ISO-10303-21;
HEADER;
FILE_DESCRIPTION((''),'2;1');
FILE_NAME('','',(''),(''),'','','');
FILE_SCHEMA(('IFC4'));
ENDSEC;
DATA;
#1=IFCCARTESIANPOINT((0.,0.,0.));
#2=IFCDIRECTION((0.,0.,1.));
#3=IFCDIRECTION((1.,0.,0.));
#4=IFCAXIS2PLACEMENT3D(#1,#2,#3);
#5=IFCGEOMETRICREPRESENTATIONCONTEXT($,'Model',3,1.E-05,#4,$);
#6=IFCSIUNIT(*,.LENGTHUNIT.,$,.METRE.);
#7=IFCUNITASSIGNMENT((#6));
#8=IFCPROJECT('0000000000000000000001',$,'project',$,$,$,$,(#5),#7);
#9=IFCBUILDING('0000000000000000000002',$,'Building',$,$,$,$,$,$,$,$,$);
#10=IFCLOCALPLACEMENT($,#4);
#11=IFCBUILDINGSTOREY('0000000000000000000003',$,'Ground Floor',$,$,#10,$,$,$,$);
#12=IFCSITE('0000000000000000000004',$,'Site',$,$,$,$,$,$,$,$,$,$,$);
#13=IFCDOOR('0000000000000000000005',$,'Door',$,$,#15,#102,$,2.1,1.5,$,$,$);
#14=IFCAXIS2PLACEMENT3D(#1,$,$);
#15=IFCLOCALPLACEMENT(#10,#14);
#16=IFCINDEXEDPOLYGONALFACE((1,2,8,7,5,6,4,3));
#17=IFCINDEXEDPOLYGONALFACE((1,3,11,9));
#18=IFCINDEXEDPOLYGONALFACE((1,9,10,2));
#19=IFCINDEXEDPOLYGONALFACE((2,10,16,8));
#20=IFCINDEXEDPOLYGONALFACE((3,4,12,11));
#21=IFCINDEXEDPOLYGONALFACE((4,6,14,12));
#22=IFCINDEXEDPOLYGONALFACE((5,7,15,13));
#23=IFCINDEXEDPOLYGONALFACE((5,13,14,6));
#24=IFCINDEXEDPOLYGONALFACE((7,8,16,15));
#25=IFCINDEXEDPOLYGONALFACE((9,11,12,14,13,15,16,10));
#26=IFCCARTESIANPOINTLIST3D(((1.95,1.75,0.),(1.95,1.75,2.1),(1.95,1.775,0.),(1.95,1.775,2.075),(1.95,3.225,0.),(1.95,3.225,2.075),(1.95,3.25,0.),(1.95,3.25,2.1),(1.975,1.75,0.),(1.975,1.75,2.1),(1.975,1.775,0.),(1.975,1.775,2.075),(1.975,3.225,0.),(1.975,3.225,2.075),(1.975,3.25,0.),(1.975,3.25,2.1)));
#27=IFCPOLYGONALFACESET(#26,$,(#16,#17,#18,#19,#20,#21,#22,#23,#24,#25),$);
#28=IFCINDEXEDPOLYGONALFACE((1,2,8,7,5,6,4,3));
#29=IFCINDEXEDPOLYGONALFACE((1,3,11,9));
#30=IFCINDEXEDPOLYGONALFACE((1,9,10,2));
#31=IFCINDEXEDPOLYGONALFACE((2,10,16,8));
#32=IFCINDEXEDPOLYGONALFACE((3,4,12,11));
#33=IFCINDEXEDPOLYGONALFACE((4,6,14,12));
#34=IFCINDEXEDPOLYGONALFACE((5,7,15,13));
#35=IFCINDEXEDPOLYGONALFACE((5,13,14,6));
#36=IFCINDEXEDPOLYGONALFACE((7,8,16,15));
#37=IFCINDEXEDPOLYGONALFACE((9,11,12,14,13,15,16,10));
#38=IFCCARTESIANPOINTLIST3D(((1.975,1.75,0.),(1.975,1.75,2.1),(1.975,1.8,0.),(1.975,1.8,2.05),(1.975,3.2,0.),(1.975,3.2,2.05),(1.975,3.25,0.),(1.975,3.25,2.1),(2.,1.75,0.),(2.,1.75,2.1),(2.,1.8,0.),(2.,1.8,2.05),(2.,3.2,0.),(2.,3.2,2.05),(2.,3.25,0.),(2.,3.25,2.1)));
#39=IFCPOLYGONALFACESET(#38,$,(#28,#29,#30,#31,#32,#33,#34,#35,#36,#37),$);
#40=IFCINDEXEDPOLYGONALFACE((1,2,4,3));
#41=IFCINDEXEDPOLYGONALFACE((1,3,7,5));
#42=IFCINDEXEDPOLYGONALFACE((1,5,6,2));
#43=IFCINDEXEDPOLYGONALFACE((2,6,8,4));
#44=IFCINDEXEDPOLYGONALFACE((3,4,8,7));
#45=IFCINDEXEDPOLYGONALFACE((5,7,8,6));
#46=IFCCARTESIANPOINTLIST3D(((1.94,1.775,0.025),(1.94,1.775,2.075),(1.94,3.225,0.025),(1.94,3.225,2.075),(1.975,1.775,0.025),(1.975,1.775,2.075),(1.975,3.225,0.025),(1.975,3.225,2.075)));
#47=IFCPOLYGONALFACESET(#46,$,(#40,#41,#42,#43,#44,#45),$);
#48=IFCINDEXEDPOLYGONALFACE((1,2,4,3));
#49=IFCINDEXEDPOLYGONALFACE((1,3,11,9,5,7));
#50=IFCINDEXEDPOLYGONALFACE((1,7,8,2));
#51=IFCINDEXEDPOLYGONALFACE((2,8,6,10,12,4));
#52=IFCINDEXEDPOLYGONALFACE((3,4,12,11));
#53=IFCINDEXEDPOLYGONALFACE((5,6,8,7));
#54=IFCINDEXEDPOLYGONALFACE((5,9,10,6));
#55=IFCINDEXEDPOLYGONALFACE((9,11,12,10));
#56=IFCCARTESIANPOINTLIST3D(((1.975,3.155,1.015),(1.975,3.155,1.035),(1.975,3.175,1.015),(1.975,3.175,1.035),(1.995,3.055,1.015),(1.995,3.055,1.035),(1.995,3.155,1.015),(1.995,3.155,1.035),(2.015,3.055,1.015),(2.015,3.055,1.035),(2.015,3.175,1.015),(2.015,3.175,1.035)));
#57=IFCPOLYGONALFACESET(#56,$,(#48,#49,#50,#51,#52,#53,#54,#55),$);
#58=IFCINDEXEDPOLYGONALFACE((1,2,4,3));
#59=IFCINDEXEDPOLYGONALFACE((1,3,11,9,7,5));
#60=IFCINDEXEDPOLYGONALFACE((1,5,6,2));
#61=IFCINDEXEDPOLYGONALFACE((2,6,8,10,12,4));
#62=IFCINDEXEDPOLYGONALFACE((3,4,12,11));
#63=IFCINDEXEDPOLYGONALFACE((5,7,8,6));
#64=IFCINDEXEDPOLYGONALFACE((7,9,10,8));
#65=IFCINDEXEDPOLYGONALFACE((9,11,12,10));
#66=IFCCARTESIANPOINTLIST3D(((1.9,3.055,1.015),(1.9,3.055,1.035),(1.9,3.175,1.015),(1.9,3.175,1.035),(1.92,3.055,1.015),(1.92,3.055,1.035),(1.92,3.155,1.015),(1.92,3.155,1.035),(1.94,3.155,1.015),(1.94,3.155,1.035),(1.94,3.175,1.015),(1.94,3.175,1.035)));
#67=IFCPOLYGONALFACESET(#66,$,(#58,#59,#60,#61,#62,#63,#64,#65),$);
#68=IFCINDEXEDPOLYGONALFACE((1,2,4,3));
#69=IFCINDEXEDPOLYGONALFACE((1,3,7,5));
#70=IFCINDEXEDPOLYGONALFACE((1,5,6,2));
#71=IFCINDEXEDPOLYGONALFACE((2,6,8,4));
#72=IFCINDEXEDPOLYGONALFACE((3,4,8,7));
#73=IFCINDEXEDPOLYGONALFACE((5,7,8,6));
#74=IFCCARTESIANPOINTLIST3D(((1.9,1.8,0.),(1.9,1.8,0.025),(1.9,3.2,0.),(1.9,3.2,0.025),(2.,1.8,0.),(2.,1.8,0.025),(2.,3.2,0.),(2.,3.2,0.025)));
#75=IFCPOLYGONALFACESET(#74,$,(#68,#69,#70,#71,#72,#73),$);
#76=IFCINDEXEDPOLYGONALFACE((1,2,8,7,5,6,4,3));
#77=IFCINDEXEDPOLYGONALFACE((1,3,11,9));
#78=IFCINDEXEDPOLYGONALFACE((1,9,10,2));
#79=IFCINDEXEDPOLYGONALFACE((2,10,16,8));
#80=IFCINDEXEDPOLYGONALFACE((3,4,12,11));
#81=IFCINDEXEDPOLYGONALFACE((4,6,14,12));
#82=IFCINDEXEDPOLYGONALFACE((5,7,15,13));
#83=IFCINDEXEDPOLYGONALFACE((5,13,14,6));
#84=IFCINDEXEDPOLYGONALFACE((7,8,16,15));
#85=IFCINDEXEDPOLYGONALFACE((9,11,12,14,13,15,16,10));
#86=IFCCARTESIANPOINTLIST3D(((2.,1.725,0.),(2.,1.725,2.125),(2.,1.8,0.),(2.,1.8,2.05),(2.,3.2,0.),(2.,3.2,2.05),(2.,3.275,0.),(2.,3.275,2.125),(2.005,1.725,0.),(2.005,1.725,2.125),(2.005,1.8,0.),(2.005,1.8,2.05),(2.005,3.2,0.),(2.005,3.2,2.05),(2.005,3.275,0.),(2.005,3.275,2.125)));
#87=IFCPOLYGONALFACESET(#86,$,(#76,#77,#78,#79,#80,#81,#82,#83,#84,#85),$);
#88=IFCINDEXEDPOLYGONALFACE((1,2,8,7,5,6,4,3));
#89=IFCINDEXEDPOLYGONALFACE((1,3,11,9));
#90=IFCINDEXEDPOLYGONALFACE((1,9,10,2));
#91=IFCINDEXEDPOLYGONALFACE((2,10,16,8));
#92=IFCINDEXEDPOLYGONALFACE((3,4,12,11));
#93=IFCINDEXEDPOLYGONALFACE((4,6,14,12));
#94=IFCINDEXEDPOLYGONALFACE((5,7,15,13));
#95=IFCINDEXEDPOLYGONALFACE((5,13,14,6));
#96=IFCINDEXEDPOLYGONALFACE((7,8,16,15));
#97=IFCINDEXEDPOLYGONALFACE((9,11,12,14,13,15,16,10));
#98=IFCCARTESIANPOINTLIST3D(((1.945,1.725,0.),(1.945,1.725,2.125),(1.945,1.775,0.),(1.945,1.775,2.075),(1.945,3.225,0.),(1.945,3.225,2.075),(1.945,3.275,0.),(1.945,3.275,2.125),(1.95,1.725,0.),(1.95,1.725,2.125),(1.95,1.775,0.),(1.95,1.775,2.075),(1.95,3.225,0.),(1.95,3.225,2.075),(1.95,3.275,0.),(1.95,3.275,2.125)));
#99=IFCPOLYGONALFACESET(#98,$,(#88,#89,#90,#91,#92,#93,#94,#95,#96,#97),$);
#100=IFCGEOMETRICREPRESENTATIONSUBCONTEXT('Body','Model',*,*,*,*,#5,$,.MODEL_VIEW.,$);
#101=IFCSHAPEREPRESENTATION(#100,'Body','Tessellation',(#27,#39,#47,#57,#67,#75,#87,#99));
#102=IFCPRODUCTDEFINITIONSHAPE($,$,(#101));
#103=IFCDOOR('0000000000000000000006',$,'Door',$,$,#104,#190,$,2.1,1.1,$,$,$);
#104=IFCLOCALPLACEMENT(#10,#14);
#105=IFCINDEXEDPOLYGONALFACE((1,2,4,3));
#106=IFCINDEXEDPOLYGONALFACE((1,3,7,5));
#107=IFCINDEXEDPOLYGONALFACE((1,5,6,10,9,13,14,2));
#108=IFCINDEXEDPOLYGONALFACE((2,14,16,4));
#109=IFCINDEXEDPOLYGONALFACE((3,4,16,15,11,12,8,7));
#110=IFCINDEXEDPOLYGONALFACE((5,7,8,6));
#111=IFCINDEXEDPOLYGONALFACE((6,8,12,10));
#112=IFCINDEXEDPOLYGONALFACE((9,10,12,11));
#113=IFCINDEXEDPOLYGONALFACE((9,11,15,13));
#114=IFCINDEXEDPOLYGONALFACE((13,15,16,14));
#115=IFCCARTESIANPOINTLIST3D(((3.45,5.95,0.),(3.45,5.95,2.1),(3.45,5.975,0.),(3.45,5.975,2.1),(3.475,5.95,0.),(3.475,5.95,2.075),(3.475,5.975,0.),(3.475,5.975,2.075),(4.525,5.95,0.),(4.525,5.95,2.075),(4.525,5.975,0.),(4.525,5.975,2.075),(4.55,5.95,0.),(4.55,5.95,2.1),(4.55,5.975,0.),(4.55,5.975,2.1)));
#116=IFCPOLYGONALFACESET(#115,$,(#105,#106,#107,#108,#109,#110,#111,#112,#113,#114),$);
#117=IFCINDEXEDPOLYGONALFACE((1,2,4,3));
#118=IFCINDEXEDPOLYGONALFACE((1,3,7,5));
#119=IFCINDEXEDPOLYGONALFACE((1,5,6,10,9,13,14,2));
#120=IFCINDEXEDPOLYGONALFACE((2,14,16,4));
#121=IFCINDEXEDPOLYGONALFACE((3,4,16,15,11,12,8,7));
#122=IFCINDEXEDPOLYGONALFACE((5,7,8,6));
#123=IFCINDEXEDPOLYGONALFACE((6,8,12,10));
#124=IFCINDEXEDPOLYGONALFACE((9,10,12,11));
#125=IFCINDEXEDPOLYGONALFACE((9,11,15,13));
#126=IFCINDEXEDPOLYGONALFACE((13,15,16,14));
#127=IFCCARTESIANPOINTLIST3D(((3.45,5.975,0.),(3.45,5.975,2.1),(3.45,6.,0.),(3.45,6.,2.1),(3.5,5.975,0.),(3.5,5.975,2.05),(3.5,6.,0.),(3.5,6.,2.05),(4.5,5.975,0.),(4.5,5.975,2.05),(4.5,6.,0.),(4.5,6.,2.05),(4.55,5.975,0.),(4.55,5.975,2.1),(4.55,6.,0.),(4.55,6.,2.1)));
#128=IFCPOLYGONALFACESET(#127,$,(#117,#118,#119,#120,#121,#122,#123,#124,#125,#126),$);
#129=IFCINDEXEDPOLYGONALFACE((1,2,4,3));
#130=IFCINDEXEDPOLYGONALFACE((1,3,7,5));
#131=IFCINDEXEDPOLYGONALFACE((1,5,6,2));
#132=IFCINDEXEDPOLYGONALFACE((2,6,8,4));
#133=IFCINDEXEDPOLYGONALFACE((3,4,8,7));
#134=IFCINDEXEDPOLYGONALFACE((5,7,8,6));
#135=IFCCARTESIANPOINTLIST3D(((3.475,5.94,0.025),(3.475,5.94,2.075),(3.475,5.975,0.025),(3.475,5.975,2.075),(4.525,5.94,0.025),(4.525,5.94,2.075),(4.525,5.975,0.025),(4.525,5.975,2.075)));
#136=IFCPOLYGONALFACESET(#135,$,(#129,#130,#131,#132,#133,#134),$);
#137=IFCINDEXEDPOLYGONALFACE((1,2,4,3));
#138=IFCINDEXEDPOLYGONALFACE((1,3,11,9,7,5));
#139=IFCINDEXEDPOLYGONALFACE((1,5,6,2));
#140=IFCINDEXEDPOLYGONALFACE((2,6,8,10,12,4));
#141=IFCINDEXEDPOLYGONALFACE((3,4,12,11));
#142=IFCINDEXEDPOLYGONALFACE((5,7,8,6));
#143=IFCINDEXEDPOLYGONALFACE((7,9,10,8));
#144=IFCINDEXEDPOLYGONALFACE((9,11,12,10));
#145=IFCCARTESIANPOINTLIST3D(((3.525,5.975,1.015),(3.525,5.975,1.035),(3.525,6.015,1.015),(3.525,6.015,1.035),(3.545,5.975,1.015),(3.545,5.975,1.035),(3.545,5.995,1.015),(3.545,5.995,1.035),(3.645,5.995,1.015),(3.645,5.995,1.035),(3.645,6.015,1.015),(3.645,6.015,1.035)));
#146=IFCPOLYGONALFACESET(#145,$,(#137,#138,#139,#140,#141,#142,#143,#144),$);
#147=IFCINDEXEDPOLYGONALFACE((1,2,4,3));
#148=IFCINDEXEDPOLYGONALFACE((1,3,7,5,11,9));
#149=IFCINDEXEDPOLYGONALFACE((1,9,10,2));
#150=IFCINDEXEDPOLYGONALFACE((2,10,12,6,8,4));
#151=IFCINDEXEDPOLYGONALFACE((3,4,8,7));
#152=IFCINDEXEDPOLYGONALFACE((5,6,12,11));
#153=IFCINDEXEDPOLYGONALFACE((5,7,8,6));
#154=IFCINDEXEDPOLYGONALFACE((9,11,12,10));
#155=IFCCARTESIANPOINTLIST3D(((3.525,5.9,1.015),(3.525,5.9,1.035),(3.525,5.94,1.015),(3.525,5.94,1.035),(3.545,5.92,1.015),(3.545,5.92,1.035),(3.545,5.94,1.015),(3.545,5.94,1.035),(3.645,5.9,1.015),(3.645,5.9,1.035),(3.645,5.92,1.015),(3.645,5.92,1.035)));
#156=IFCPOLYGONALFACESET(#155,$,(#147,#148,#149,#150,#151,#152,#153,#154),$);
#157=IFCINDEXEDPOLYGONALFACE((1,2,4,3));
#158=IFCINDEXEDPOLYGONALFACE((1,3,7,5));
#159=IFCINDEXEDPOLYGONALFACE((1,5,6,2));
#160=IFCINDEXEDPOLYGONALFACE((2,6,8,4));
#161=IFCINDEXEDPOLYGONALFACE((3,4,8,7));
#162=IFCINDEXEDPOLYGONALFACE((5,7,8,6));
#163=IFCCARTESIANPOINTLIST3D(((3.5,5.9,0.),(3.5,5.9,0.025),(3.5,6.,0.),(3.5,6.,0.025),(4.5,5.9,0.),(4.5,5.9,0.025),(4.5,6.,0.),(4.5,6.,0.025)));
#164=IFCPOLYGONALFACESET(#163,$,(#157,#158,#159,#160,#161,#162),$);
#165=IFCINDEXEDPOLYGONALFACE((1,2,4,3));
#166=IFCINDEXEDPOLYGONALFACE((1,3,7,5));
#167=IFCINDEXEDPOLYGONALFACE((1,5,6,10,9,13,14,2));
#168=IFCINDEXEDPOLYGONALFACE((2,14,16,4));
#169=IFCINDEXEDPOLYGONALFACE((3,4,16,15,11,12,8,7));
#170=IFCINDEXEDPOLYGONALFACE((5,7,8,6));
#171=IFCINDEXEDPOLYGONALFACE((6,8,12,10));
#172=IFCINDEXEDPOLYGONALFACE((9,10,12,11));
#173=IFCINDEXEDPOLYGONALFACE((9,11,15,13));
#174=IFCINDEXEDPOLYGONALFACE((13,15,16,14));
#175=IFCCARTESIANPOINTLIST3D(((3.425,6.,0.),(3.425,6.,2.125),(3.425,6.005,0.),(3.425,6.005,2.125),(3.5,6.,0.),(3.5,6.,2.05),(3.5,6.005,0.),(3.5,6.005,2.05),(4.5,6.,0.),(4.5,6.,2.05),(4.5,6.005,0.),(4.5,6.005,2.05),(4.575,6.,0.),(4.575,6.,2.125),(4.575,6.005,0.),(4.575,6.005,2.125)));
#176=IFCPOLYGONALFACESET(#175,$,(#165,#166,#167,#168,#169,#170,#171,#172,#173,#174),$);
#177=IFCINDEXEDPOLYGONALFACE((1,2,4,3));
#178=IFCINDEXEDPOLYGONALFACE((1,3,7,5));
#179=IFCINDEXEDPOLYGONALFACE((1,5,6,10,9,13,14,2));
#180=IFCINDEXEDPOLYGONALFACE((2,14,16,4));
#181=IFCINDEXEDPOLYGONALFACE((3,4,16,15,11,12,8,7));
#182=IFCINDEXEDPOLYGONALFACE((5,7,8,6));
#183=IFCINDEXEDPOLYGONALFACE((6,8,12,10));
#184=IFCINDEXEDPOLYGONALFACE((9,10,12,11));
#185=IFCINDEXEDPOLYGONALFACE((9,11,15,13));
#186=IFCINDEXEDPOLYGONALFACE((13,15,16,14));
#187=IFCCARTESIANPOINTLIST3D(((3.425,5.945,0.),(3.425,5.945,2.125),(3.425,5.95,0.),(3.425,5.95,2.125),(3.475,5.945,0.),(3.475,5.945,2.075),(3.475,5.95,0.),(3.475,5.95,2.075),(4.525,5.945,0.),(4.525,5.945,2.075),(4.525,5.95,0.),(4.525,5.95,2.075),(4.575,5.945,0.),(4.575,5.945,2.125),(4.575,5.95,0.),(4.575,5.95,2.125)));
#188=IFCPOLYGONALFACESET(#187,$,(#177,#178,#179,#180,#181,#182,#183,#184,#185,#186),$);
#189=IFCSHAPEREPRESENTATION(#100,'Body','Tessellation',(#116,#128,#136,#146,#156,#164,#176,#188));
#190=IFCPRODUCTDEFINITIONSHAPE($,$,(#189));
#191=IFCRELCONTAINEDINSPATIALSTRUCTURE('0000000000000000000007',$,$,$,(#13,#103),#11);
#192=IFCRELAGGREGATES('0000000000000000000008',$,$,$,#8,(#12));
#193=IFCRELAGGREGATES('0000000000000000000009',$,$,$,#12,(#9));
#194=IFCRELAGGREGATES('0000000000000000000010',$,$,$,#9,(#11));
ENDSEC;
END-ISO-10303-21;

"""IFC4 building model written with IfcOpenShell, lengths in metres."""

from ifc_helpers import new_model, si_unit, frame, origin_with_axes, place, context, subcontext, project, spatial, line, indexed_curve, outline, extrude, element, save


model = new_model("IFC4")

# Units and contexts
model_context = context("Model", 3, precision=1e-05, world=origin_with_axes())
body_context = subcontext(model_context, "Body", "Model", "MODEL_VIEW")
ifc_project = project(units=[si_unit("LENGTHUNIT", "METRE")], contexts=[model_context])

# Site, building, storey
site = spatial("IfcSite", under=ifc_project, Name="Site")
building = spatial("IfcBuilding", under=site, Name="Building")
storey_placement = place(None, origin_with_axes())
storey = spatial("IfcBuildingStorey", under=building, at=storey_placement, Name="Ground Floor")

# Doors
door_1_placement = place(storey_placement, frame((2.0, 1.75, 0.0), z_axis=(0.0, 0.0, 1.0), x_axis=(0.0, 1.0, 0.0)))
element("IfcDoor", 1, at=door_1_placement, inside=storey, Name="Door", OverallHeight=2.1, OverallWidth=1.5, context=body_context, shape_type="SweptSolid", body=[
    extrude(outline(indexed_curve([(0.0, 0.0), (0.0, 2.1), (1.5, 2.1), (1.5, 0.0), (1.475, 0.0), (1.475, 2.075), (0.025, 2.075), (0.025, 0.0)], segments=[line(1, 2, 3, 4, 5, 6, 7, 8, 1)])), frame((0.0, 0.025, 0.0), z_axis=(0.0, -1.0, 0.0), x_axis=(1.0, 0.0, 0.0)), (0.0, 0.0, -1.0), 0.025),
    extrude(outline(indexed_curve([(0.0, 0.0), (0.0, 2.1), (1.5, 2.1), (1.5, 0.0), (1.45, 0.0), (1.45, 2.05), (0.05, 2.05), (0.05, 0.0)], segments=[line(1, 2, 3, 4, 5, 6, 7, 8, 1)])), frame((0.0, 0.0, 0.0), z_axis=(0.0, -1.0, 0.0), x_axis=(1.0, 0.0, 0.0)), (0.0, 0.0, -1.0), 0.025),
    extrude(outline(indexed_curve([(0.0, 0.0), (1.45, 0.0), (1.45, 0.035), (0.0, 0.035)], segments=[line(1, 2, 3, 4, 1)])), frame((0.025, 0.025, 0.025), z_axis=(0.0, 0.0, 1.0), x_axis=(1.0, 0.0, 0.0)), (0.0, 0.0, 1.0), 2.05),
    extrude(outline(indexed_curve([(0.0, 0.0), (0.0, -0.04), (-0.12, -0.04), (-0.12, -0.02), (-0.02, -0.02), (-0.02, 0.0)], segments=[line(1, 2, 3, 4, 5, 6, 1)])), frame((1.425, 0.025, 1.015), z_axis=(0.0, 0.0, 1.0), x_axis=(1.0, 0.0, 0.0)), (0.0, 0.0, 1.0), 0.02),
    extrude(outline(indexed_curve([(0.0, 0.0), (0.0, 0.04), (-0.12, 0.04), (-0.12, 0.02), (-0.02, 0.02), (-0.02, 0.0)], segments=[line(1, 2, 3, 4, 5, 6, 1)])), frame((1.425, 0.06, 1.015), z_axis=(0.0, 0.0, 1.0), x_axis=(1.0, 0.0, 0.0)), (0.0, 0.0, 1.0), 0.02),
    extrude(outline(indexed_curve([(0.0, 0.0), (1.4, 0.0), (1.4, 0.1), (0.0, 0.1)], segments=[line(1, 2, 3, 4, 1)])), frame((0.05, 0.0, 0.0), z_axis=(0.0, 0.0, 1.0), x_axis=(1.0, 0.0, 0.0)), (0.0, 0.0, 1.0), 0.025),
    extrude(outline(indexed_curve([(0.0, 0.0), (0.0, 2.125), (1.55, 2.125), (1.55, 0.0), (1.475, 0.0), (1.475, 2.05), (0.075, 2.05), (0.075, 0.0)], segments=[line(1, 2, 3, 4, 5, 6, 7, 8, 1)])), frame((-0.025, -0.005, 0.0), z_axis=(0.0, -1.0, 0.0), x_axis=(1.0, 0.0, 0.0)), (0.0, 0.0, -1.0), 0.005),
    extrude(outline(indexed_curve([(0.0, 0.0), (0.0, 2.125), (1.55, 2.125), (1.55, 0.0), (1.5, 0.0), (1.5, 2.075), (0.05, 2.075), (0.05, 0.0)], segments=[line(1, 2, 3, 4, 5, 6, 7, 8, 1)])), frame((-0.025, 0.05, 0.0), z_axis=(0.0, -1.0, 0.0), x_axis=(1.0, 0.0, 0.0)), (0.0, 0.0, -1.0), 0.005),
])
door_2_placement = place(storey_placement, frame((4.55, 6.0, 0.0), z_axis=(0.0, 0.0, 1.0), x_axis=(-1.0, 0.0, 0.0)))
element("IfcDoor", 2, at=door_2_placement, inside=storey, Name="Door", OverallHeight=2.1, OverallWidth=1.1, context=body_context, shape_type="SweptSolid", body=[
    extrude(outline(indexed_curve([(0.0, 0.0), (0.0, 2.1), (1.1, 2.1), (1.1, 0.0), (1.075, 0.0), (1.075, 2.075), (0.025, 2.075), (0.025, 0.0)], segments=[line(1, 2, 3, 4, 5, 6, 7, 8, 1)])), frame((0.0, 0.025, 0.0), z_axis=(0.0, -1.0, 0.0), x_axis=(1.0, 0.0, 0.0)), (0.0, 0.0, -1.0), 0.025),
    extrude(outline(indexed_curve([(0.0, 0.0), (0.0, 2.1), (1.1, 2.1), (1.1, 0.0), (1.05, 0.0), (1.05, 2.05), (0.05, 2.05), (0.05, 0.0)], segments=[line(1, 2, 3, 4, 5, 6, 7, 8, 1)])), frame((0.0, 0.0, 0.0), z_axis=(0.0, -1.0, 0.0), x_axis=(1.0, 0.0, 0.0)), (0.0, 0.0, -1.0), 0.025),
    extrude(outline(indexed_curve([(0.0, 0.0), (1.05, 0.0), (1.05, 0.035), (0.0, 0.035)], segments=[line(1, 2, 3, 4, 1)])), frame((0.025, 0.025, 0.025), z_axis=(0.0, 0.0, 1.0), x_axis=(1.0, 0.0, 0.0)), (0.0, 0.0, 1.0), 2.05),
    extrude(outline(indexed_curve([(0.0, 0.0), (0.0, -0.04), (-0.12, -0.04), (-0.12, -0.02), (-0.02, -0.02), (-0.02, 0.0)], segments=[line(1, 2, 3, 4, 5, 6, 1)])), frame((1.025, 0.025, 1.015), z_axis=(0.0, 0.0, 1.0), x_axis=(1.0, 0.0, 0.0)), (0.0, 0.0, 1.0), 0.02),
    extrude(outline(indexed_curve([(0.0, 0.0), (0.0, 0.04), (-0.12, 0.04), (-0.12, 0.02), (-0.02, 0.02), (-0.02, 0.0)], segments=[line(1, 2, 3, 4, 5, 6, 1)])), frame((1.025, 0.06, 1.015), z_axis=(0.0, 0.0, 1.0), x_axis=(1.0, 0.0, 0.0)), (0.0, 0.0, 1.0), 0.02),
    extrude(outline(indexed_curve([(0.0, 0.0), (1.0, 0.0), (1.0, 0.1), (0.0, 0.1)], segments=[line(1, 2, 3, 4, 1)])), frame((0.05, 0.0, 0.0), z_axis=(0.0, 0.0, 1.0), x_axis=(1.0, 0.0, 0.0)), (0.0, 0.0, 1.0), 0.025),
    extrude(outline(indexed_curve([(0.0, 0.0), (0.0, 2.125), (1.15, 2.125), (1.15, 0.0), (1.075, 0.0), (1.075, 2.05), (0.075, 2.05), (0.075, 0.0)], segments=[line(1, 2, 3, 4, 5, 6, 7, 8, 1)])), frame((-0.025, -0.005, 0.0), z_axis=(0.0, -1.0, 0.0), x_axis=(1.0, 0.0, 0.0)), (0.0, 0.0, -1.0), 0.005),
    extrude(outline(indexed_curve([(0.0, 0.0), (0.0, 2.125), (1.15, 2.125), (1.15, 0.0), (1.1, 0.0), (1.1, 2.075), (0.05, 2.075), (0.05, 0.0)], segments=[line(1, 2, 3, 4, 5, 6, 7, 8, 1)])), frame((-0.025, 0.05, 0.0), z_axis=(0.0, -1.0, 0.0), x_axis=(1.0, 0.0, 0.0)), (0.0, 0.0, -1.0), 0.005),
])

save(model, "model.ifc")
